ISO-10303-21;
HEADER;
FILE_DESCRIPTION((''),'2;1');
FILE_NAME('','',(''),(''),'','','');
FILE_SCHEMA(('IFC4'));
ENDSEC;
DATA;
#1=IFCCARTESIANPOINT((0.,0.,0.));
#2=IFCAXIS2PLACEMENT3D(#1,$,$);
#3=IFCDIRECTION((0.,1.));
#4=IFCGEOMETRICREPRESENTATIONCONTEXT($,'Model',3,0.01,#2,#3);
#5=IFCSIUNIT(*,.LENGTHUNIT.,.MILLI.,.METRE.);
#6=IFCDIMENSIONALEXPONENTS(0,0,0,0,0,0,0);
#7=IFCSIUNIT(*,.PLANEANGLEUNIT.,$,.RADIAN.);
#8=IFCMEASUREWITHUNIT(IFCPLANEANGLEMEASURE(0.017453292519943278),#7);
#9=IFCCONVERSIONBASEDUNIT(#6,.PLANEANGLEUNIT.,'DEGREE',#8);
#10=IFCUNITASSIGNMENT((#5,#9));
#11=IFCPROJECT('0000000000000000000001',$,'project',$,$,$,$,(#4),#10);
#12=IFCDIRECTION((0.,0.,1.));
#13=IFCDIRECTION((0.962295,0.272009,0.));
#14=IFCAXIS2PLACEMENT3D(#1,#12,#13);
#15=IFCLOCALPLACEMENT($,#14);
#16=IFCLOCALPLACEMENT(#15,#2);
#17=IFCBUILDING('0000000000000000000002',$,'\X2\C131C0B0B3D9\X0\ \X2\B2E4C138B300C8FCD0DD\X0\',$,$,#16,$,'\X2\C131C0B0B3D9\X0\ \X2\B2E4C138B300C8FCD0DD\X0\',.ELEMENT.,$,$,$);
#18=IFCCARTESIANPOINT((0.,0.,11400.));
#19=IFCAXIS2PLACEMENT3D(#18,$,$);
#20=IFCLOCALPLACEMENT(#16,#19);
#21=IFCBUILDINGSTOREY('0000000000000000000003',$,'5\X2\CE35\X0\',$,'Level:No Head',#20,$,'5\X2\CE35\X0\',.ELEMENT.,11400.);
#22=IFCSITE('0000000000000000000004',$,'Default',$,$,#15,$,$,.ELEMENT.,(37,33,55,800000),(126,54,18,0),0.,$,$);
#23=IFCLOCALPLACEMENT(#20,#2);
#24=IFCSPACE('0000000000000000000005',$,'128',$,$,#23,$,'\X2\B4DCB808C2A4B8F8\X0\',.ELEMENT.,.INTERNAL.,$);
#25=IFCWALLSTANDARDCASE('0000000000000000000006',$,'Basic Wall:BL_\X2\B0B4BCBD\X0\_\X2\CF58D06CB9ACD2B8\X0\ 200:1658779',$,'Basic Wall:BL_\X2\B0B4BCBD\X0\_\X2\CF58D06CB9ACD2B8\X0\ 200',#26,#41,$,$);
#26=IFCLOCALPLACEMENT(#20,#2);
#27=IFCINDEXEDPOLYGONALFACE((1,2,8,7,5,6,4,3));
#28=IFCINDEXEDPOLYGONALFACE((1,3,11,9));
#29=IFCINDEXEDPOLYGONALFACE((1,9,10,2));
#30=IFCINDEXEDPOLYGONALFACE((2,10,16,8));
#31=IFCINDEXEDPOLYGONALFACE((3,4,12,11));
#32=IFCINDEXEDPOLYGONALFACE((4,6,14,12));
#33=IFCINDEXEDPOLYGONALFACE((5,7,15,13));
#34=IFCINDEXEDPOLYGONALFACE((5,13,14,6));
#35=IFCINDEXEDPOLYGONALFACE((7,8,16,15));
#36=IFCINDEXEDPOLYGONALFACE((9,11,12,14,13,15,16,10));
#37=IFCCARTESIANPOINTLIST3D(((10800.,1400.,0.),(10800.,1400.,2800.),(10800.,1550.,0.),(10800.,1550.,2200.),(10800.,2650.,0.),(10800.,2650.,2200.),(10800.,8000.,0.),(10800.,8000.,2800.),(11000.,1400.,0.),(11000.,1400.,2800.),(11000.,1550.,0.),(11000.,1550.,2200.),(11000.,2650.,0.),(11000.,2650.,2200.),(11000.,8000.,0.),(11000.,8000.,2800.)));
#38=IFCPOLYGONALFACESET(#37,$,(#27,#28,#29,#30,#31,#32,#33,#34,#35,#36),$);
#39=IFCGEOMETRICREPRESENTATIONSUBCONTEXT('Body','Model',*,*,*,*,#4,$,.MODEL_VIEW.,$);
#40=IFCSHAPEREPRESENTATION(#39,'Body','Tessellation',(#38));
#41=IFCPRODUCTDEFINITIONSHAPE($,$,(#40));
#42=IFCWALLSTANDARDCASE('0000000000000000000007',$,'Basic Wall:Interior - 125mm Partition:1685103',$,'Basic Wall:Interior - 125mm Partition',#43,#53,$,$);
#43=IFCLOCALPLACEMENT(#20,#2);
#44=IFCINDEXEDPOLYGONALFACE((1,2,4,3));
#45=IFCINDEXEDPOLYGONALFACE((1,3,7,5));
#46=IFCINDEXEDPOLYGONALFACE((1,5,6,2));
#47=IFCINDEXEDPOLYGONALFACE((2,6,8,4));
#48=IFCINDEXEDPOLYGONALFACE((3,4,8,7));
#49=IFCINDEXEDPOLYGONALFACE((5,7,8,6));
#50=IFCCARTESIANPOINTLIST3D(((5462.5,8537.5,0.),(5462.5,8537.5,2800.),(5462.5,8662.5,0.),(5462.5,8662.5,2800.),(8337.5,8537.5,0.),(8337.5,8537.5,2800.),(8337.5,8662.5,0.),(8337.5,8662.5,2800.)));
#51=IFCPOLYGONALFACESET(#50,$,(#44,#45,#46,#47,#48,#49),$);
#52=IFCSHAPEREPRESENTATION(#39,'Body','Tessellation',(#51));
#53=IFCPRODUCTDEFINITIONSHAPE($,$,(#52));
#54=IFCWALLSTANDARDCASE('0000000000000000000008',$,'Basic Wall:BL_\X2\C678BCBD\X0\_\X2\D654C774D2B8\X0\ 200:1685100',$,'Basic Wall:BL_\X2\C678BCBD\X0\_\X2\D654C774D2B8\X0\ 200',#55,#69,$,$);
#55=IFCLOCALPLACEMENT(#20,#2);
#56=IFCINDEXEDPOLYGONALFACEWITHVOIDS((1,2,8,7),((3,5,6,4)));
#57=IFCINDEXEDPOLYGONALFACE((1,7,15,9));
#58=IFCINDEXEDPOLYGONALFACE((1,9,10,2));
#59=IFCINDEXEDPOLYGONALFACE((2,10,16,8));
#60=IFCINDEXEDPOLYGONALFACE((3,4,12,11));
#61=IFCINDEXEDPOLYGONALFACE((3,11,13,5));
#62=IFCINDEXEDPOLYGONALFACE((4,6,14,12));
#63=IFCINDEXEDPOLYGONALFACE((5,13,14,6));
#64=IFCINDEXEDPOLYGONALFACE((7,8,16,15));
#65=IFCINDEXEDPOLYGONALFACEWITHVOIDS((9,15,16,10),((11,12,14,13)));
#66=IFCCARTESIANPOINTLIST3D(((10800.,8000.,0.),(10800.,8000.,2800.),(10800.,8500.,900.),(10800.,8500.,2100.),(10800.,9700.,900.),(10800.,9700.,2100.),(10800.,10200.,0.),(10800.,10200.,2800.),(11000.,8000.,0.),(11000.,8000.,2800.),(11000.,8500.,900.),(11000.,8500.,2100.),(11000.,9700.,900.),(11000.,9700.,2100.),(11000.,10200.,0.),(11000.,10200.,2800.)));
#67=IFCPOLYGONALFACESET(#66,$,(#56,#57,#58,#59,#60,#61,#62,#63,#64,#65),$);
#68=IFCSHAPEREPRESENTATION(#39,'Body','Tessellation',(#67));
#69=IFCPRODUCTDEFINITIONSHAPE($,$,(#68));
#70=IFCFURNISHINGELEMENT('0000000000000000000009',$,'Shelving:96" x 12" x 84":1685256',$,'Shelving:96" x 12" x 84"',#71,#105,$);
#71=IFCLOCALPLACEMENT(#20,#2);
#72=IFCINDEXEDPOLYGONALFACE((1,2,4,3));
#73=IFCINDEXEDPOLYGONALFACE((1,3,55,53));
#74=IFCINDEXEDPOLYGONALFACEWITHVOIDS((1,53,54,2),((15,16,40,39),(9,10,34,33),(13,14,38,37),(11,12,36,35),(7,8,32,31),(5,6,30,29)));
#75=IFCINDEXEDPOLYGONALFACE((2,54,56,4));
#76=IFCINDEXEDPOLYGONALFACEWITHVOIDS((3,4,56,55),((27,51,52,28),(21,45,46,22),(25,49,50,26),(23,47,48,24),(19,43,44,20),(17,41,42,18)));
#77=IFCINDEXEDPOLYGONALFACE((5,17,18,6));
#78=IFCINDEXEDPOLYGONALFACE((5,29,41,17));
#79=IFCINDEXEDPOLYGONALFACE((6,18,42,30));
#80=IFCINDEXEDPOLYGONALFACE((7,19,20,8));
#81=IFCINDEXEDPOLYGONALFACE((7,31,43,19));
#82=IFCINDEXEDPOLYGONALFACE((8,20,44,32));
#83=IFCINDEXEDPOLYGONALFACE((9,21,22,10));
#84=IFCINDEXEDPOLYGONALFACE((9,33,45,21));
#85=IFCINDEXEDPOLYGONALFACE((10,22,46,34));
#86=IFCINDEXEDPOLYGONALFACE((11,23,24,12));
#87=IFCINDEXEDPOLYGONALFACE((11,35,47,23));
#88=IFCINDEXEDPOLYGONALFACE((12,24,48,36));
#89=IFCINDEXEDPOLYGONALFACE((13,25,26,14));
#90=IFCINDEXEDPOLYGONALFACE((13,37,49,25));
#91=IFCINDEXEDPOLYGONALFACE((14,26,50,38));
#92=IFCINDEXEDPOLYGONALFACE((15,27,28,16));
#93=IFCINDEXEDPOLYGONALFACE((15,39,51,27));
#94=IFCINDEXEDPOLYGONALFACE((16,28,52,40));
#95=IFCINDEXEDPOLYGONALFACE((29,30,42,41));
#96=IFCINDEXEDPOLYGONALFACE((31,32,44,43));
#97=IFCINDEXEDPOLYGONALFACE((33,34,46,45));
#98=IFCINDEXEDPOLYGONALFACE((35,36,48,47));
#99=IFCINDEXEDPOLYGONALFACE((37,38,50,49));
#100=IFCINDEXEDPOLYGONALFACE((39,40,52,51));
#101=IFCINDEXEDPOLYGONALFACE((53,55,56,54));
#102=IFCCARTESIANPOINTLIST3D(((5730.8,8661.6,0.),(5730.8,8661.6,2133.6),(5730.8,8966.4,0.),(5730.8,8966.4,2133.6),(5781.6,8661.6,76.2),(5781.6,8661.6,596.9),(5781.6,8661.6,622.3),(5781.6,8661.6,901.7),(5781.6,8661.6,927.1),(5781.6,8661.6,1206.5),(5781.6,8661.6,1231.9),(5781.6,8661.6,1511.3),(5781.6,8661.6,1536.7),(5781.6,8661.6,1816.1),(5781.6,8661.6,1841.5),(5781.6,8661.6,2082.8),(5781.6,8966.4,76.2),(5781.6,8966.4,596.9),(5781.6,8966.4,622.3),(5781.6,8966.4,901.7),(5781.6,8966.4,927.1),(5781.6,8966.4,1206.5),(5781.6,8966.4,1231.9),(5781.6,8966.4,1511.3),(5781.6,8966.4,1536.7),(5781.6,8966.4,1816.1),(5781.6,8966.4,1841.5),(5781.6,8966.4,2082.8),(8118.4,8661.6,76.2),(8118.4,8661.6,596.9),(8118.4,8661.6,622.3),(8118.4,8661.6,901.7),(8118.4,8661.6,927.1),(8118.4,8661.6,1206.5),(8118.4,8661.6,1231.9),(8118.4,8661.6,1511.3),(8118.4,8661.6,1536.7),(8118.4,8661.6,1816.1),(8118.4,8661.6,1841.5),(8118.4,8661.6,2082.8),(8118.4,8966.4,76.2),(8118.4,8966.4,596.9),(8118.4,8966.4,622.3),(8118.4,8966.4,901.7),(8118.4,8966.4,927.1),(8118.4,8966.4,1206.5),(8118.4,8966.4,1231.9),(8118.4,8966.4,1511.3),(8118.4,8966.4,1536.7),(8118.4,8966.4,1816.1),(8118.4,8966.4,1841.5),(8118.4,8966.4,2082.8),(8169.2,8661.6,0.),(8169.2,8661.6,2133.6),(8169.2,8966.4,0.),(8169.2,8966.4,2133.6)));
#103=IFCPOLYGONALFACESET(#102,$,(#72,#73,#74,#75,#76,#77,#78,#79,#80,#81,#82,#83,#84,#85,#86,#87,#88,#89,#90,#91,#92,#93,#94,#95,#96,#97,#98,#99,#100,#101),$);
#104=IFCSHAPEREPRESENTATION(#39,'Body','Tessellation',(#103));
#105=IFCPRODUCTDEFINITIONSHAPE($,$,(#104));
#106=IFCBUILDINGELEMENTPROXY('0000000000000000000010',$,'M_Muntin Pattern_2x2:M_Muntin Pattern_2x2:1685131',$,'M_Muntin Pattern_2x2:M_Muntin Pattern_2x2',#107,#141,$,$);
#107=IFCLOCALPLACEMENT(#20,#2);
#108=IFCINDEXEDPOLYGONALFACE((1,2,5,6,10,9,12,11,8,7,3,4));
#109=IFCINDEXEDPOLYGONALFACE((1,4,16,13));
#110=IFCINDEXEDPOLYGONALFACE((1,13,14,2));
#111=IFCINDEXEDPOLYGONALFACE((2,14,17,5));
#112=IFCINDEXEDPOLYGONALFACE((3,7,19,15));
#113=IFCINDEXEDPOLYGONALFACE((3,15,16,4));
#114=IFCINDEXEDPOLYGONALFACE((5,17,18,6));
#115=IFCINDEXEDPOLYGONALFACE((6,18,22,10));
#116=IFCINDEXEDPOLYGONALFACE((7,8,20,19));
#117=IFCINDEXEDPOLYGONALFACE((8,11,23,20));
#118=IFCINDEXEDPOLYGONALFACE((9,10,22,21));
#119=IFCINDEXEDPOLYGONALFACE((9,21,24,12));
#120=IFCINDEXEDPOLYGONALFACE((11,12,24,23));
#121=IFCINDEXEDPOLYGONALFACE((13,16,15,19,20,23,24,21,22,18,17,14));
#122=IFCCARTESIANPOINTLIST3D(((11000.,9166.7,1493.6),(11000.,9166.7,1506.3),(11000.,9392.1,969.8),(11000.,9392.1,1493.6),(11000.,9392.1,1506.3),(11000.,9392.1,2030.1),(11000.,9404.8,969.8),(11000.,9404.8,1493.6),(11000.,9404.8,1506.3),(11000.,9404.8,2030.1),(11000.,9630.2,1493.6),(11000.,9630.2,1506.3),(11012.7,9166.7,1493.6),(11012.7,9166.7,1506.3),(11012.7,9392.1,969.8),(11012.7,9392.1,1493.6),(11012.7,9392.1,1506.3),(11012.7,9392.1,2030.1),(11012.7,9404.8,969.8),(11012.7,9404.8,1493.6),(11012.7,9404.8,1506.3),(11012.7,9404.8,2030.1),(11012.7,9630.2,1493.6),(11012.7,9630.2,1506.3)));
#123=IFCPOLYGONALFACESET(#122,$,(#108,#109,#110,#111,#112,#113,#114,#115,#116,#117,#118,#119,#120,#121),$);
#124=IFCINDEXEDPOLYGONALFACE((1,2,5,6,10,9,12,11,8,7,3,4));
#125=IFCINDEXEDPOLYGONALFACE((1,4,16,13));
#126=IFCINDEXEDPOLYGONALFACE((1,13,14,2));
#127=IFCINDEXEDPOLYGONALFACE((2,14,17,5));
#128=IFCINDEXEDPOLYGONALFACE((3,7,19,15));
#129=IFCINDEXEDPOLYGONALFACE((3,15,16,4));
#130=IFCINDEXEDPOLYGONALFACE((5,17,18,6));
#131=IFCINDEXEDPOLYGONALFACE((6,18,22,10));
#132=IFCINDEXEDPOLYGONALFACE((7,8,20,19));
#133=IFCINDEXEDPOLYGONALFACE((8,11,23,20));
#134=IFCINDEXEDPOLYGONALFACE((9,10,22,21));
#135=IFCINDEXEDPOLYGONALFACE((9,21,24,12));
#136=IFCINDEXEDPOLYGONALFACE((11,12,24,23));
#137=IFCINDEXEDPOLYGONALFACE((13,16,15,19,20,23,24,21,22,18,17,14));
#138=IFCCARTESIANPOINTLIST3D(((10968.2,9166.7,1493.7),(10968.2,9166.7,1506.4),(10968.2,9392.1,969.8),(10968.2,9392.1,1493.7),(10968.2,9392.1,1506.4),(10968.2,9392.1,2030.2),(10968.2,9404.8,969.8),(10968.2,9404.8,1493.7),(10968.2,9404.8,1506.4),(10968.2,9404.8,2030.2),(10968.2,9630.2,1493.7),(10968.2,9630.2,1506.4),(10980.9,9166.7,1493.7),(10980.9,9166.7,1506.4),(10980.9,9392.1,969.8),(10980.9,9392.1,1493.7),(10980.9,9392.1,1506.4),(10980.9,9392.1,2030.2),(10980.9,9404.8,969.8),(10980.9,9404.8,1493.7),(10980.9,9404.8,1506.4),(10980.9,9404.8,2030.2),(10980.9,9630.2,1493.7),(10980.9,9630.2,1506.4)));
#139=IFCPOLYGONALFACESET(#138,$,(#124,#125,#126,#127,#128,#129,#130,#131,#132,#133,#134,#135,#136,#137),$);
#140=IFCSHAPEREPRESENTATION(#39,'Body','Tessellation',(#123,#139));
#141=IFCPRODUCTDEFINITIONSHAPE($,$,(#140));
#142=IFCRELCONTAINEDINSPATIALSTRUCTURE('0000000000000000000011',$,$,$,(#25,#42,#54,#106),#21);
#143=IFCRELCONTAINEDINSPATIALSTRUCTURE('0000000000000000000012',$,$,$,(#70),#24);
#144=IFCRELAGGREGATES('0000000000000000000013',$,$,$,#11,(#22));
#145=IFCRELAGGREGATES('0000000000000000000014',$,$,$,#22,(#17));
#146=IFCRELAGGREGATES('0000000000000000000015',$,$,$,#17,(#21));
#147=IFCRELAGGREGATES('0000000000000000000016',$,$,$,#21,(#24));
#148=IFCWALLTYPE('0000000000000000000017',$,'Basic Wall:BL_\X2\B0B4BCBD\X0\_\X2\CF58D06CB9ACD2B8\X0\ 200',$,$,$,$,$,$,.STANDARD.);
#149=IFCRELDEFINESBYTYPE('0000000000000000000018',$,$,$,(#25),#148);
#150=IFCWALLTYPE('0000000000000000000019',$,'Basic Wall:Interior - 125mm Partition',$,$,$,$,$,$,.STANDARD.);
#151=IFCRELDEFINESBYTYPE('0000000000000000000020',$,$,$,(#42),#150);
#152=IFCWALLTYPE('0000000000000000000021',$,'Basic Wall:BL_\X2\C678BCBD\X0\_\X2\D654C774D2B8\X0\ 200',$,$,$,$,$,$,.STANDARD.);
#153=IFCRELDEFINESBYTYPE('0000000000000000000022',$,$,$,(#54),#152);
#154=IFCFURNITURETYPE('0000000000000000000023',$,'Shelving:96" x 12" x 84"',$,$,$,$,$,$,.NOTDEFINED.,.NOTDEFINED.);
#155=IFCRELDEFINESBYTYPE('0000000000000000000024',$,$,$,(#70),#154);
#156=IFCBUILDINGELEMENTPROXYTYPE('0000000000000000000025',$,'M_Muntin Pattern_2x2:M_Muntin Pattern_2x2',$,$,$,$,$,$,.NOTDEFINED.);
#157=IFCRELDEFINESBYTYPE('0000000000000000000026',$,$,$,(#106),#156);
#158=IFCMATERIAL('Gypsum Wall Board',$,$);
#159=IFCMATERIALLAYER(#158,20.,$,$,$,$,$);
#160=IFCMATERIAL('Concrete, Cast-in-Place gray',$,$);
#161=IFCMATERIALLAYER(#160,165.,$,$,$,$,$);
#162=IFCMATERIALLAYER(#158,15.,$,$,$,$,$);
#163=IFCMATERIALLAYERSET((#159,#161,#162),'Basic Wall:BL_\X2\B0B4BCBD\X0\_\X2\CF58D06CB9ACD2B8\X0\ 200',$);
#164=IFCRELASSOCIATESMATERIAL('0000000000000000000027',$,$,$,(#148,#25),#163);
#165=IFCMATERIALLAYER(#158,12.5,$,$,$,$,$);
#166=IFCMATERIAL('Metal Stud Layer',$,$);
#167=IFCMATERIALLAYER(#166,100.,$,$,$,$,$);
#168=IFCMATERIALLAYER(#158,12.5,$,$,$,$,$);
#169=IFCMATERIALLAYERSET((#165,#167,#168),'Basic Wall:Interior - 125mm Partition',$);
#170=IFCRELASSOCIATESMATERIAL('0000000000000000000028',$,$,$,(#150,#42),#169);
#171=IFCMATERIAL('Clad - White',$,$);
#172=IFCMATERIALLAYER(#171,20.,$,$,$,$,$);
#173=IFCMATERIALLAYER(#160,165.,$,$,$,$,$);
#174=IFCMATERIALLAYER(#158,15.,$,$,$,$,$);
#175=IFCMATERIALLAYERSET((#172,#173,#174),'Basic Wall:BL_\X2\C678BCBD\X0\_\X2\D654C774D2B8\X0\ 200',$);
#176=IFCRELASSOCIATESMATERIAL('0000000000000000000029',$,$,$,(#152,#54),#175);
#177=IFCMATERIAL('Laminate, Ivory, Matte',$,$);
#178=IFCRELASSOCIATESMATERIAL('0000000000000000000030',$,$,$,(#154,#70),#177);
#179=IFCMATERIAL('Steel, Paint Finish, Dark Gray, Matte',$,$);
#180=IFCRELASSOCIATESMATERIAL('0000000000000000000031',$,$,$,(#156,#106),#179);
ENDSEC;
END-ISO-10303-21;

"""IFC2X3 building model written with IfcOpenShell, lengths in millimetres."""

from ifc_helpers import new_model, entity, si_unit, converted_unit, direction, frame, frame_2d, origin, place, context, subcontext, project, spatial, polyline, rectangle, outline, extrude, source, transform, mapped, material, layer, layer_set, layer_usage, type_object, type_shapes, element, save


model = new_model("IFC2X3")

# Units and contexts
model_context = context("Model", 3, precision=0.01, world=origin(), true_north=direction((0.0, 1.0)))
body_context = subcontext(model_context, "Body", "Model", "MODEL_VIEW")
ifc_project = project(units=[si_unit("LENGTHUNIT", "METRE", prefix="MILLI"), converted_unit("PLANEANGLEUNIT", "DEGREE", entity("IfcPlaneAngleMeasure", 0.017453292519943278), si_unit("PLANEANGLEUNIT", "RADIAN"), dimensions=[0, 0, 0, 0, 0, 0, 0])], contexts=[model_context])

# Site, building, storey
site_placement = place(None, frame((0.0, 0.0, 0.0), z_axis=(0.0, 0.0, 1.0), x_axis=(0.962295, 0.272009, 0.0)))
site = spatial("IfcSite", under=ifc_project, at=site_placement, Name="Default", CompositionType="ELEMENT", RefLatitude=(37, 33, 55, 800000), RefLongitude=(126, 54, 18, 0), RefElevation=0.0)
building_placement = place(site_placement, origin())
building = spatial("IfcBuilding", under=site, at=building_placement, Name="성산동 다세대주택", LongName="성산동 다세대주택", CompositionType="ELEMENT")
storey_placement = place(building_placement, frame((0.0, 0.0, 11400.0)))
storey = spatial("IfcBuildingStorey", under=building, at=storey_placement, Name="5층", ObjectType="Level:No Head", LongName="5층", CompositionType="ELEMENT", Elevation=11400.0)

# Wall, openings
ifc_material_1 = material(Name="Gypsum Wall Board")
ifc_layer_1 = layer(ifc_material_1, 20.0)
ifc_material_2 = material(Name="Concrete, Cast-in-Place gray")
ifc_layer_2 = layer(ifc_material_2, 165.0)
ifc_layer_3 = layer(ifc_material_1, 15.0)
ifc_layer_set_1 = layer_set([ifc_layer_1, ifc_layer_2, ifc_layer_3], Name="Basic Wall:BL_내벽_콘크리트 200")
ifc_layer_usage_1 = layer_usage(ifc_layer_set_1, "AXIS2", "NEGATIVE", 100.0)
wall_type_1 = type_object("IfcWallType", Name="Basic Wall:BL_내벽_콘크리트 200", PredefinedType="STANDARD", material=ifc_layer_set_1)
wall_1_placement = place(storey_placement, frame((10900.0, 8000.0, 0.0), z_axis=(0.0, 0.0, 1.0), x_axis=(0.0, -1.0, 0.0)))
wall_1 = element("IfcWallStandardCase", 1, at=wall_1_placement, inside=storey, type_object=wall_type_1, material=ifc_layer_usage_1, Name="Basic Wall:BL_내벽_콘크리트 200:1658779", ObjectType="Basic Wall:BL_내벽_콘크리트 200", context=body_context, shape_type="SweptSolid", body=[
    extrude(rectangle(XDim=6600.0, YDim=200.0, at=frame_2d((3300.0, 0.0), x_axis=(1.0, 0.0))), origin(), (0.0, 0.0, 1.0), 2800.0),
])
opening_1_placement = place(wall_1_placement, origin())
element("IfcOpeningElement", 2, at=opening_1_placement, cuts=wall_1, ObjectType="Opening", context=body_context, shape_type="SweptSolid", body=[
    extrude(rectangle(XDim=2200.0, YDim=1000.0, at=frame_2d((0.0, 0.0), x_axis=(0.0, 1.0))), frame((5900.0, -1624.0, 3900.0), z_axis=(0.0, 1.0, 0.0), x_axis=(-1.0, 0.0, 0.0)), (0.0, 0.0, 1.0), 3048.0),
])
opening_2_placement = place(wall_1_placement, frame((5350.0, -100.0, 0.0)))
element("IfcOpeningElement", 3, at=opening_2_placement, cuts=wall_1, ObjectType="Opening", context=body_context, shape_type="SweptSolid", body=[
    extrude(rectangle(XDim=2200.0, YDim=1100.0, at=frame_2d((1100.0, 550.0), x_axis=(1.0, 0.0))), frame((0.0, 0.0, 0.0), z_axis=(0.0, 1.0, 0.0), x_axis=(0.0, 0.0, 1.0)), (0.0, 0.0, 1.0), 200.0),
])

# Wall
ifc_layer_4 = layer(ifc_material_1, 12.5)
ifc_material_3 = material(Name="Metal Stud Layer")
ifc_layer_5 = layer(ifc_material_3, 100.0)
ifc_layer_6 = layer(ifc_material_1, 12.5)
ifc_layer_set_2 = layer_set([ifc_layer_4, ifc_layer_5, ifc_layer_6], Name="Basic Wall:Interior - 125mm Partition")
ifc_layer_usage_2 = layer_usage(ifc_layer_set_2, "AXIS2", "NEGATIVE", 62.5)
wall_type_2 = type_object("IfcWallType", Name="Basic Wall:Interior - 125mm Partition", PredefinedType="STANDARD", material=ifc_layer_set_2)
wall_2_placement = place(storey_placement, frame((5462.5, 8600.0, 0.0)))
element("IfcWallStandardCase", 4, at=wall_2_placement, inside=storey, type_object=wall_type_2, material=ifc_layer_usage_2, Name="Basic Wall:Interior - 125mm Partition:1685103", ObjectType="Basic Wall:Interior - 125mm Partition", context=body_context, shape_type="SweptSolid", body=[
    extrude(rectangle(XDim=2875.0, YDim=125.0, at=frame_2d((1437.5, 0.0), x_axis=(-1.0, 0.0))), origin(), (0.0, 0.0, 1.0), 2800.0),
])

# Wall, opening
ifc_material_4 = material(Name="Clad - White")
ifc_layer_7 = layer(ifc_material_4, 20.0)
ifc_layer_8 = layer(ifc_material_2, 165.0)
ifc_layer_9 = layer(ifc_material_1, 15.0)
ifc_layer_set_3 = layer_set([ifc_layer_7, ifc_layer_8, ifc_layer_9], Name="Basic Wall:BL_외벽_화이트 200")
ifc_layer_usage_3 = layer_usage(ifc_layer_set_3, "AXIS2", "NEGATIVE", 100.0)
wall_type_3 = type_object("IfcWallType", Name="Basic Wall:BL_외벽_화이트 200", PredefinedType="STANDARD", material=ifc_layer_set_3)
wall_3_placement = place(storey_placement, frame((10900.0, 10200.0, 0.0), z_axis=(0.0, 0.0, 1.0), x_axis=(0.0, -1.0, 0.0)))
wall_3 = element("IfcWallStandardCase", 5, at=wall_3_placement, inside=storey, type_object=wall_type_3, material=ifc_layer_usage_3, Name="Basic Wall:BL_외벽_화이트 200:1685100", ObjectType="Basic Wall:BL_외벽_화이트 200", context=body_context, shape_type="SweptSolid", body=[
    extrude(rectangle(XDim=2200.0, YDim=200.0, at=frame_2d((1100.0, 0.0), x_axis=(-1.0, 0.0))), origin(), (0.0, 0.0, 1.0), 2800.0),
])
opening_3_placement = place(wall_3_placement, frame((500.0, -100.0, 900.0)))
element("IfcOpeningElement", 6, at=opening_3_placement, cuts=wall_3, ObjectType="Opening", context=body_context, shape_type="SweptSolid", body=[
    extrude(rectangle(XDim=1200.0, YDim=1200.0, at=frame_2d((600.0, 600.0), x_axis=(-1.0, 0.0))), frame((0.0, 0.0, 0.0), z_axis=(0.0, 1.0, 0.0), x_axis=(0.0, 0.0, 1.0)), (0.0, 0.0, 1.0), 200.0),
])

# Shared definitions
space_1_placement = place(storey_placement, origin())
space_1 = spatial("IfcSpace", under=storey, at=space_1_placement, Name="128", LongName="드레스룸", CompositionType="ELEMENT", InteriorOrExteriorSpace="INTERNAL")

# Furnishing element
ifc_material_5 = material(Name="Laminate, Ivory, Matte")
furniture_type_1 = type_object("IfcFurnitureType", Name="Shelving:96\" x 12\" x 84\"", AssemblyPlace="NOTDEFINED", material=ifc_material_5)
shared_shape_1 = source(origin(), body_context, "Body", "SweptSolid", [
    extrude(outline(polyline([(-1219.2, -1066.8), (1219.2, -1066.8), (1219.2, 1066.8), (-1219.2, 1066.8), (-1219.2, -1066.8)]), holes=[polyline([(-1168.4, 1016.0), (1168.4, 1016.0), (1168.4, 774.7), (-1168.4, 774.7), (-1168.4, 1016.0)]), polyline([(-1168.4, -990.6), (-1168.4, -469.9), (1168.4, -469.9), (1168.4, -990.6), (-1168.4, -990.6)]), polyline([(1168.4, 165.1), (-1168.4, 165.1), (-1168.4, 444.5), (1168.4, 444.5), (1168.4, 165.1)]), polyline([(-1168.4, 749.3), (1168.4, 749.3), (1168.4, 469.9), (-1168.4, 469.9), (-1168.4, 749.3)]), polyline([(-1168.4, 139.7), (1168.4, 139.7), (1168.4, -139.7), (-1168.4, -139.7), (-1168.4, 139.7)]), polyline([(-1168.4, -165.1), (1168.4, -165.1), (1168.4, -444.5), (-1168.4, -444.5), (-1168.4, -165.1)])]), frame((0.0, -457.2, 1066.8), z_axis=(0.0, 1.0, 0.0), x_axis=(-1.0, 0.0, 0.0)), (0.0, 0.0, 1.0), 304.8),
])
type_shapes(furniture_type_1, [shared_shape_1])
furnishing_1_placement = place(space_1_placement, frame((6950.0, 8509.2, 0.0), z_axis=(0.0, 0.0, 1.0), x_axis=(-1.0, 0.0, 0.0)))
element("IfcFurnishingElement", 7, at=furnishing_1_placement, inside=space_1, type_object=furniture_type_1, material=ifc_material_5, Name="Shelving:96\" x 12\" x 84\":1685256", ObjectType="Shelving:96\" x 12\" x 84\"", context=body_context, shape_type="MappedRepresentation", body=[
    mapped(shared_shape_1, transform((0.0, 0.0, 0.0), scale=1.0)),
])

# Building element proxy
ifc_material_6 = material(Name="Steel, Paint Finish, Dark Gray, Matte")
building_element_proxy_type_1 = type_object("IfcBuildingElementProxyType", Name="M_Muntin Pattern_2x2:M_Muntin Pattern_2x2", PredefinedType="NOTDEFINED", material=ifc_material_6)
shared_shape_2 = source(origin(), body_context, "Body", "SweptSolid", [
    extrude(outline(polyline([(6.4, -6.4), (530.1, -6.4), (530.1, 6.3), (6.4, 6.3), (6.4, 231.7), (-6.3, 231.7), (-6.3, 6.3), (-530.2, 6.3), (-530.2, -6.4), (-6.3, -6.4), (-6.3, -231.7), (6.4, -231.7), (6.4, -6.4)])), frame((0.0, 9.5, 530.1), z_axis=(0.0, 1.0, 0.0), x_axis=(0.0, 0.0, 1.0)), (0.0, 0.0, 1.0), 12.7),
    extrude(outline(polyline([(6.4, -6.4), (530.2, -6.4), (530.2, 6.3), (6.4, 6.3), (6.4, 231.7), (-6.3, 231.7), (-6.3, 6.3), (-530.2, 6.3), (-530.2, -6.4), (-6.3, -6.4), (-6.3, -231.7), (6.4, -231.7), (6.4, -6.4)])), frame((0.0, -22.2, 530.2), z_axis=(0.0, 1.0, 0.0), x_axis=(0.0, 0.0, 1.0)), (0.0, 0.0, 1.0), 12.7),
])
type_shapes(building_element_proxy_type_1, [shared_shape_2])
proxy_1_placement = place(storey_placement, frame((10990.5, 9398.4, 969.8), z_axis=(0.0, 0.0, 1.0), x_axis=(0.0, -1.0, 0.0)))
element("IfcBuildingElementProxy", 8, at=proxy_1_placement, inside=storey, type_object=building_element_proxy_type_1, material=ifc_material_6, Name="M_Muntin Pattern_2x2:M_Muntin Pattern_2x2:1685131", ObjectType="M_Muntin Pattern_2x2:M_Muntin Pattern_2x2", context=body_context, shape_type="MappedRepresentation", body=[
    mapped(shared_shape_2, transform((0.0, 0.0, 0.0), scale=1.0)),
])

save(model, "model.ifc")
